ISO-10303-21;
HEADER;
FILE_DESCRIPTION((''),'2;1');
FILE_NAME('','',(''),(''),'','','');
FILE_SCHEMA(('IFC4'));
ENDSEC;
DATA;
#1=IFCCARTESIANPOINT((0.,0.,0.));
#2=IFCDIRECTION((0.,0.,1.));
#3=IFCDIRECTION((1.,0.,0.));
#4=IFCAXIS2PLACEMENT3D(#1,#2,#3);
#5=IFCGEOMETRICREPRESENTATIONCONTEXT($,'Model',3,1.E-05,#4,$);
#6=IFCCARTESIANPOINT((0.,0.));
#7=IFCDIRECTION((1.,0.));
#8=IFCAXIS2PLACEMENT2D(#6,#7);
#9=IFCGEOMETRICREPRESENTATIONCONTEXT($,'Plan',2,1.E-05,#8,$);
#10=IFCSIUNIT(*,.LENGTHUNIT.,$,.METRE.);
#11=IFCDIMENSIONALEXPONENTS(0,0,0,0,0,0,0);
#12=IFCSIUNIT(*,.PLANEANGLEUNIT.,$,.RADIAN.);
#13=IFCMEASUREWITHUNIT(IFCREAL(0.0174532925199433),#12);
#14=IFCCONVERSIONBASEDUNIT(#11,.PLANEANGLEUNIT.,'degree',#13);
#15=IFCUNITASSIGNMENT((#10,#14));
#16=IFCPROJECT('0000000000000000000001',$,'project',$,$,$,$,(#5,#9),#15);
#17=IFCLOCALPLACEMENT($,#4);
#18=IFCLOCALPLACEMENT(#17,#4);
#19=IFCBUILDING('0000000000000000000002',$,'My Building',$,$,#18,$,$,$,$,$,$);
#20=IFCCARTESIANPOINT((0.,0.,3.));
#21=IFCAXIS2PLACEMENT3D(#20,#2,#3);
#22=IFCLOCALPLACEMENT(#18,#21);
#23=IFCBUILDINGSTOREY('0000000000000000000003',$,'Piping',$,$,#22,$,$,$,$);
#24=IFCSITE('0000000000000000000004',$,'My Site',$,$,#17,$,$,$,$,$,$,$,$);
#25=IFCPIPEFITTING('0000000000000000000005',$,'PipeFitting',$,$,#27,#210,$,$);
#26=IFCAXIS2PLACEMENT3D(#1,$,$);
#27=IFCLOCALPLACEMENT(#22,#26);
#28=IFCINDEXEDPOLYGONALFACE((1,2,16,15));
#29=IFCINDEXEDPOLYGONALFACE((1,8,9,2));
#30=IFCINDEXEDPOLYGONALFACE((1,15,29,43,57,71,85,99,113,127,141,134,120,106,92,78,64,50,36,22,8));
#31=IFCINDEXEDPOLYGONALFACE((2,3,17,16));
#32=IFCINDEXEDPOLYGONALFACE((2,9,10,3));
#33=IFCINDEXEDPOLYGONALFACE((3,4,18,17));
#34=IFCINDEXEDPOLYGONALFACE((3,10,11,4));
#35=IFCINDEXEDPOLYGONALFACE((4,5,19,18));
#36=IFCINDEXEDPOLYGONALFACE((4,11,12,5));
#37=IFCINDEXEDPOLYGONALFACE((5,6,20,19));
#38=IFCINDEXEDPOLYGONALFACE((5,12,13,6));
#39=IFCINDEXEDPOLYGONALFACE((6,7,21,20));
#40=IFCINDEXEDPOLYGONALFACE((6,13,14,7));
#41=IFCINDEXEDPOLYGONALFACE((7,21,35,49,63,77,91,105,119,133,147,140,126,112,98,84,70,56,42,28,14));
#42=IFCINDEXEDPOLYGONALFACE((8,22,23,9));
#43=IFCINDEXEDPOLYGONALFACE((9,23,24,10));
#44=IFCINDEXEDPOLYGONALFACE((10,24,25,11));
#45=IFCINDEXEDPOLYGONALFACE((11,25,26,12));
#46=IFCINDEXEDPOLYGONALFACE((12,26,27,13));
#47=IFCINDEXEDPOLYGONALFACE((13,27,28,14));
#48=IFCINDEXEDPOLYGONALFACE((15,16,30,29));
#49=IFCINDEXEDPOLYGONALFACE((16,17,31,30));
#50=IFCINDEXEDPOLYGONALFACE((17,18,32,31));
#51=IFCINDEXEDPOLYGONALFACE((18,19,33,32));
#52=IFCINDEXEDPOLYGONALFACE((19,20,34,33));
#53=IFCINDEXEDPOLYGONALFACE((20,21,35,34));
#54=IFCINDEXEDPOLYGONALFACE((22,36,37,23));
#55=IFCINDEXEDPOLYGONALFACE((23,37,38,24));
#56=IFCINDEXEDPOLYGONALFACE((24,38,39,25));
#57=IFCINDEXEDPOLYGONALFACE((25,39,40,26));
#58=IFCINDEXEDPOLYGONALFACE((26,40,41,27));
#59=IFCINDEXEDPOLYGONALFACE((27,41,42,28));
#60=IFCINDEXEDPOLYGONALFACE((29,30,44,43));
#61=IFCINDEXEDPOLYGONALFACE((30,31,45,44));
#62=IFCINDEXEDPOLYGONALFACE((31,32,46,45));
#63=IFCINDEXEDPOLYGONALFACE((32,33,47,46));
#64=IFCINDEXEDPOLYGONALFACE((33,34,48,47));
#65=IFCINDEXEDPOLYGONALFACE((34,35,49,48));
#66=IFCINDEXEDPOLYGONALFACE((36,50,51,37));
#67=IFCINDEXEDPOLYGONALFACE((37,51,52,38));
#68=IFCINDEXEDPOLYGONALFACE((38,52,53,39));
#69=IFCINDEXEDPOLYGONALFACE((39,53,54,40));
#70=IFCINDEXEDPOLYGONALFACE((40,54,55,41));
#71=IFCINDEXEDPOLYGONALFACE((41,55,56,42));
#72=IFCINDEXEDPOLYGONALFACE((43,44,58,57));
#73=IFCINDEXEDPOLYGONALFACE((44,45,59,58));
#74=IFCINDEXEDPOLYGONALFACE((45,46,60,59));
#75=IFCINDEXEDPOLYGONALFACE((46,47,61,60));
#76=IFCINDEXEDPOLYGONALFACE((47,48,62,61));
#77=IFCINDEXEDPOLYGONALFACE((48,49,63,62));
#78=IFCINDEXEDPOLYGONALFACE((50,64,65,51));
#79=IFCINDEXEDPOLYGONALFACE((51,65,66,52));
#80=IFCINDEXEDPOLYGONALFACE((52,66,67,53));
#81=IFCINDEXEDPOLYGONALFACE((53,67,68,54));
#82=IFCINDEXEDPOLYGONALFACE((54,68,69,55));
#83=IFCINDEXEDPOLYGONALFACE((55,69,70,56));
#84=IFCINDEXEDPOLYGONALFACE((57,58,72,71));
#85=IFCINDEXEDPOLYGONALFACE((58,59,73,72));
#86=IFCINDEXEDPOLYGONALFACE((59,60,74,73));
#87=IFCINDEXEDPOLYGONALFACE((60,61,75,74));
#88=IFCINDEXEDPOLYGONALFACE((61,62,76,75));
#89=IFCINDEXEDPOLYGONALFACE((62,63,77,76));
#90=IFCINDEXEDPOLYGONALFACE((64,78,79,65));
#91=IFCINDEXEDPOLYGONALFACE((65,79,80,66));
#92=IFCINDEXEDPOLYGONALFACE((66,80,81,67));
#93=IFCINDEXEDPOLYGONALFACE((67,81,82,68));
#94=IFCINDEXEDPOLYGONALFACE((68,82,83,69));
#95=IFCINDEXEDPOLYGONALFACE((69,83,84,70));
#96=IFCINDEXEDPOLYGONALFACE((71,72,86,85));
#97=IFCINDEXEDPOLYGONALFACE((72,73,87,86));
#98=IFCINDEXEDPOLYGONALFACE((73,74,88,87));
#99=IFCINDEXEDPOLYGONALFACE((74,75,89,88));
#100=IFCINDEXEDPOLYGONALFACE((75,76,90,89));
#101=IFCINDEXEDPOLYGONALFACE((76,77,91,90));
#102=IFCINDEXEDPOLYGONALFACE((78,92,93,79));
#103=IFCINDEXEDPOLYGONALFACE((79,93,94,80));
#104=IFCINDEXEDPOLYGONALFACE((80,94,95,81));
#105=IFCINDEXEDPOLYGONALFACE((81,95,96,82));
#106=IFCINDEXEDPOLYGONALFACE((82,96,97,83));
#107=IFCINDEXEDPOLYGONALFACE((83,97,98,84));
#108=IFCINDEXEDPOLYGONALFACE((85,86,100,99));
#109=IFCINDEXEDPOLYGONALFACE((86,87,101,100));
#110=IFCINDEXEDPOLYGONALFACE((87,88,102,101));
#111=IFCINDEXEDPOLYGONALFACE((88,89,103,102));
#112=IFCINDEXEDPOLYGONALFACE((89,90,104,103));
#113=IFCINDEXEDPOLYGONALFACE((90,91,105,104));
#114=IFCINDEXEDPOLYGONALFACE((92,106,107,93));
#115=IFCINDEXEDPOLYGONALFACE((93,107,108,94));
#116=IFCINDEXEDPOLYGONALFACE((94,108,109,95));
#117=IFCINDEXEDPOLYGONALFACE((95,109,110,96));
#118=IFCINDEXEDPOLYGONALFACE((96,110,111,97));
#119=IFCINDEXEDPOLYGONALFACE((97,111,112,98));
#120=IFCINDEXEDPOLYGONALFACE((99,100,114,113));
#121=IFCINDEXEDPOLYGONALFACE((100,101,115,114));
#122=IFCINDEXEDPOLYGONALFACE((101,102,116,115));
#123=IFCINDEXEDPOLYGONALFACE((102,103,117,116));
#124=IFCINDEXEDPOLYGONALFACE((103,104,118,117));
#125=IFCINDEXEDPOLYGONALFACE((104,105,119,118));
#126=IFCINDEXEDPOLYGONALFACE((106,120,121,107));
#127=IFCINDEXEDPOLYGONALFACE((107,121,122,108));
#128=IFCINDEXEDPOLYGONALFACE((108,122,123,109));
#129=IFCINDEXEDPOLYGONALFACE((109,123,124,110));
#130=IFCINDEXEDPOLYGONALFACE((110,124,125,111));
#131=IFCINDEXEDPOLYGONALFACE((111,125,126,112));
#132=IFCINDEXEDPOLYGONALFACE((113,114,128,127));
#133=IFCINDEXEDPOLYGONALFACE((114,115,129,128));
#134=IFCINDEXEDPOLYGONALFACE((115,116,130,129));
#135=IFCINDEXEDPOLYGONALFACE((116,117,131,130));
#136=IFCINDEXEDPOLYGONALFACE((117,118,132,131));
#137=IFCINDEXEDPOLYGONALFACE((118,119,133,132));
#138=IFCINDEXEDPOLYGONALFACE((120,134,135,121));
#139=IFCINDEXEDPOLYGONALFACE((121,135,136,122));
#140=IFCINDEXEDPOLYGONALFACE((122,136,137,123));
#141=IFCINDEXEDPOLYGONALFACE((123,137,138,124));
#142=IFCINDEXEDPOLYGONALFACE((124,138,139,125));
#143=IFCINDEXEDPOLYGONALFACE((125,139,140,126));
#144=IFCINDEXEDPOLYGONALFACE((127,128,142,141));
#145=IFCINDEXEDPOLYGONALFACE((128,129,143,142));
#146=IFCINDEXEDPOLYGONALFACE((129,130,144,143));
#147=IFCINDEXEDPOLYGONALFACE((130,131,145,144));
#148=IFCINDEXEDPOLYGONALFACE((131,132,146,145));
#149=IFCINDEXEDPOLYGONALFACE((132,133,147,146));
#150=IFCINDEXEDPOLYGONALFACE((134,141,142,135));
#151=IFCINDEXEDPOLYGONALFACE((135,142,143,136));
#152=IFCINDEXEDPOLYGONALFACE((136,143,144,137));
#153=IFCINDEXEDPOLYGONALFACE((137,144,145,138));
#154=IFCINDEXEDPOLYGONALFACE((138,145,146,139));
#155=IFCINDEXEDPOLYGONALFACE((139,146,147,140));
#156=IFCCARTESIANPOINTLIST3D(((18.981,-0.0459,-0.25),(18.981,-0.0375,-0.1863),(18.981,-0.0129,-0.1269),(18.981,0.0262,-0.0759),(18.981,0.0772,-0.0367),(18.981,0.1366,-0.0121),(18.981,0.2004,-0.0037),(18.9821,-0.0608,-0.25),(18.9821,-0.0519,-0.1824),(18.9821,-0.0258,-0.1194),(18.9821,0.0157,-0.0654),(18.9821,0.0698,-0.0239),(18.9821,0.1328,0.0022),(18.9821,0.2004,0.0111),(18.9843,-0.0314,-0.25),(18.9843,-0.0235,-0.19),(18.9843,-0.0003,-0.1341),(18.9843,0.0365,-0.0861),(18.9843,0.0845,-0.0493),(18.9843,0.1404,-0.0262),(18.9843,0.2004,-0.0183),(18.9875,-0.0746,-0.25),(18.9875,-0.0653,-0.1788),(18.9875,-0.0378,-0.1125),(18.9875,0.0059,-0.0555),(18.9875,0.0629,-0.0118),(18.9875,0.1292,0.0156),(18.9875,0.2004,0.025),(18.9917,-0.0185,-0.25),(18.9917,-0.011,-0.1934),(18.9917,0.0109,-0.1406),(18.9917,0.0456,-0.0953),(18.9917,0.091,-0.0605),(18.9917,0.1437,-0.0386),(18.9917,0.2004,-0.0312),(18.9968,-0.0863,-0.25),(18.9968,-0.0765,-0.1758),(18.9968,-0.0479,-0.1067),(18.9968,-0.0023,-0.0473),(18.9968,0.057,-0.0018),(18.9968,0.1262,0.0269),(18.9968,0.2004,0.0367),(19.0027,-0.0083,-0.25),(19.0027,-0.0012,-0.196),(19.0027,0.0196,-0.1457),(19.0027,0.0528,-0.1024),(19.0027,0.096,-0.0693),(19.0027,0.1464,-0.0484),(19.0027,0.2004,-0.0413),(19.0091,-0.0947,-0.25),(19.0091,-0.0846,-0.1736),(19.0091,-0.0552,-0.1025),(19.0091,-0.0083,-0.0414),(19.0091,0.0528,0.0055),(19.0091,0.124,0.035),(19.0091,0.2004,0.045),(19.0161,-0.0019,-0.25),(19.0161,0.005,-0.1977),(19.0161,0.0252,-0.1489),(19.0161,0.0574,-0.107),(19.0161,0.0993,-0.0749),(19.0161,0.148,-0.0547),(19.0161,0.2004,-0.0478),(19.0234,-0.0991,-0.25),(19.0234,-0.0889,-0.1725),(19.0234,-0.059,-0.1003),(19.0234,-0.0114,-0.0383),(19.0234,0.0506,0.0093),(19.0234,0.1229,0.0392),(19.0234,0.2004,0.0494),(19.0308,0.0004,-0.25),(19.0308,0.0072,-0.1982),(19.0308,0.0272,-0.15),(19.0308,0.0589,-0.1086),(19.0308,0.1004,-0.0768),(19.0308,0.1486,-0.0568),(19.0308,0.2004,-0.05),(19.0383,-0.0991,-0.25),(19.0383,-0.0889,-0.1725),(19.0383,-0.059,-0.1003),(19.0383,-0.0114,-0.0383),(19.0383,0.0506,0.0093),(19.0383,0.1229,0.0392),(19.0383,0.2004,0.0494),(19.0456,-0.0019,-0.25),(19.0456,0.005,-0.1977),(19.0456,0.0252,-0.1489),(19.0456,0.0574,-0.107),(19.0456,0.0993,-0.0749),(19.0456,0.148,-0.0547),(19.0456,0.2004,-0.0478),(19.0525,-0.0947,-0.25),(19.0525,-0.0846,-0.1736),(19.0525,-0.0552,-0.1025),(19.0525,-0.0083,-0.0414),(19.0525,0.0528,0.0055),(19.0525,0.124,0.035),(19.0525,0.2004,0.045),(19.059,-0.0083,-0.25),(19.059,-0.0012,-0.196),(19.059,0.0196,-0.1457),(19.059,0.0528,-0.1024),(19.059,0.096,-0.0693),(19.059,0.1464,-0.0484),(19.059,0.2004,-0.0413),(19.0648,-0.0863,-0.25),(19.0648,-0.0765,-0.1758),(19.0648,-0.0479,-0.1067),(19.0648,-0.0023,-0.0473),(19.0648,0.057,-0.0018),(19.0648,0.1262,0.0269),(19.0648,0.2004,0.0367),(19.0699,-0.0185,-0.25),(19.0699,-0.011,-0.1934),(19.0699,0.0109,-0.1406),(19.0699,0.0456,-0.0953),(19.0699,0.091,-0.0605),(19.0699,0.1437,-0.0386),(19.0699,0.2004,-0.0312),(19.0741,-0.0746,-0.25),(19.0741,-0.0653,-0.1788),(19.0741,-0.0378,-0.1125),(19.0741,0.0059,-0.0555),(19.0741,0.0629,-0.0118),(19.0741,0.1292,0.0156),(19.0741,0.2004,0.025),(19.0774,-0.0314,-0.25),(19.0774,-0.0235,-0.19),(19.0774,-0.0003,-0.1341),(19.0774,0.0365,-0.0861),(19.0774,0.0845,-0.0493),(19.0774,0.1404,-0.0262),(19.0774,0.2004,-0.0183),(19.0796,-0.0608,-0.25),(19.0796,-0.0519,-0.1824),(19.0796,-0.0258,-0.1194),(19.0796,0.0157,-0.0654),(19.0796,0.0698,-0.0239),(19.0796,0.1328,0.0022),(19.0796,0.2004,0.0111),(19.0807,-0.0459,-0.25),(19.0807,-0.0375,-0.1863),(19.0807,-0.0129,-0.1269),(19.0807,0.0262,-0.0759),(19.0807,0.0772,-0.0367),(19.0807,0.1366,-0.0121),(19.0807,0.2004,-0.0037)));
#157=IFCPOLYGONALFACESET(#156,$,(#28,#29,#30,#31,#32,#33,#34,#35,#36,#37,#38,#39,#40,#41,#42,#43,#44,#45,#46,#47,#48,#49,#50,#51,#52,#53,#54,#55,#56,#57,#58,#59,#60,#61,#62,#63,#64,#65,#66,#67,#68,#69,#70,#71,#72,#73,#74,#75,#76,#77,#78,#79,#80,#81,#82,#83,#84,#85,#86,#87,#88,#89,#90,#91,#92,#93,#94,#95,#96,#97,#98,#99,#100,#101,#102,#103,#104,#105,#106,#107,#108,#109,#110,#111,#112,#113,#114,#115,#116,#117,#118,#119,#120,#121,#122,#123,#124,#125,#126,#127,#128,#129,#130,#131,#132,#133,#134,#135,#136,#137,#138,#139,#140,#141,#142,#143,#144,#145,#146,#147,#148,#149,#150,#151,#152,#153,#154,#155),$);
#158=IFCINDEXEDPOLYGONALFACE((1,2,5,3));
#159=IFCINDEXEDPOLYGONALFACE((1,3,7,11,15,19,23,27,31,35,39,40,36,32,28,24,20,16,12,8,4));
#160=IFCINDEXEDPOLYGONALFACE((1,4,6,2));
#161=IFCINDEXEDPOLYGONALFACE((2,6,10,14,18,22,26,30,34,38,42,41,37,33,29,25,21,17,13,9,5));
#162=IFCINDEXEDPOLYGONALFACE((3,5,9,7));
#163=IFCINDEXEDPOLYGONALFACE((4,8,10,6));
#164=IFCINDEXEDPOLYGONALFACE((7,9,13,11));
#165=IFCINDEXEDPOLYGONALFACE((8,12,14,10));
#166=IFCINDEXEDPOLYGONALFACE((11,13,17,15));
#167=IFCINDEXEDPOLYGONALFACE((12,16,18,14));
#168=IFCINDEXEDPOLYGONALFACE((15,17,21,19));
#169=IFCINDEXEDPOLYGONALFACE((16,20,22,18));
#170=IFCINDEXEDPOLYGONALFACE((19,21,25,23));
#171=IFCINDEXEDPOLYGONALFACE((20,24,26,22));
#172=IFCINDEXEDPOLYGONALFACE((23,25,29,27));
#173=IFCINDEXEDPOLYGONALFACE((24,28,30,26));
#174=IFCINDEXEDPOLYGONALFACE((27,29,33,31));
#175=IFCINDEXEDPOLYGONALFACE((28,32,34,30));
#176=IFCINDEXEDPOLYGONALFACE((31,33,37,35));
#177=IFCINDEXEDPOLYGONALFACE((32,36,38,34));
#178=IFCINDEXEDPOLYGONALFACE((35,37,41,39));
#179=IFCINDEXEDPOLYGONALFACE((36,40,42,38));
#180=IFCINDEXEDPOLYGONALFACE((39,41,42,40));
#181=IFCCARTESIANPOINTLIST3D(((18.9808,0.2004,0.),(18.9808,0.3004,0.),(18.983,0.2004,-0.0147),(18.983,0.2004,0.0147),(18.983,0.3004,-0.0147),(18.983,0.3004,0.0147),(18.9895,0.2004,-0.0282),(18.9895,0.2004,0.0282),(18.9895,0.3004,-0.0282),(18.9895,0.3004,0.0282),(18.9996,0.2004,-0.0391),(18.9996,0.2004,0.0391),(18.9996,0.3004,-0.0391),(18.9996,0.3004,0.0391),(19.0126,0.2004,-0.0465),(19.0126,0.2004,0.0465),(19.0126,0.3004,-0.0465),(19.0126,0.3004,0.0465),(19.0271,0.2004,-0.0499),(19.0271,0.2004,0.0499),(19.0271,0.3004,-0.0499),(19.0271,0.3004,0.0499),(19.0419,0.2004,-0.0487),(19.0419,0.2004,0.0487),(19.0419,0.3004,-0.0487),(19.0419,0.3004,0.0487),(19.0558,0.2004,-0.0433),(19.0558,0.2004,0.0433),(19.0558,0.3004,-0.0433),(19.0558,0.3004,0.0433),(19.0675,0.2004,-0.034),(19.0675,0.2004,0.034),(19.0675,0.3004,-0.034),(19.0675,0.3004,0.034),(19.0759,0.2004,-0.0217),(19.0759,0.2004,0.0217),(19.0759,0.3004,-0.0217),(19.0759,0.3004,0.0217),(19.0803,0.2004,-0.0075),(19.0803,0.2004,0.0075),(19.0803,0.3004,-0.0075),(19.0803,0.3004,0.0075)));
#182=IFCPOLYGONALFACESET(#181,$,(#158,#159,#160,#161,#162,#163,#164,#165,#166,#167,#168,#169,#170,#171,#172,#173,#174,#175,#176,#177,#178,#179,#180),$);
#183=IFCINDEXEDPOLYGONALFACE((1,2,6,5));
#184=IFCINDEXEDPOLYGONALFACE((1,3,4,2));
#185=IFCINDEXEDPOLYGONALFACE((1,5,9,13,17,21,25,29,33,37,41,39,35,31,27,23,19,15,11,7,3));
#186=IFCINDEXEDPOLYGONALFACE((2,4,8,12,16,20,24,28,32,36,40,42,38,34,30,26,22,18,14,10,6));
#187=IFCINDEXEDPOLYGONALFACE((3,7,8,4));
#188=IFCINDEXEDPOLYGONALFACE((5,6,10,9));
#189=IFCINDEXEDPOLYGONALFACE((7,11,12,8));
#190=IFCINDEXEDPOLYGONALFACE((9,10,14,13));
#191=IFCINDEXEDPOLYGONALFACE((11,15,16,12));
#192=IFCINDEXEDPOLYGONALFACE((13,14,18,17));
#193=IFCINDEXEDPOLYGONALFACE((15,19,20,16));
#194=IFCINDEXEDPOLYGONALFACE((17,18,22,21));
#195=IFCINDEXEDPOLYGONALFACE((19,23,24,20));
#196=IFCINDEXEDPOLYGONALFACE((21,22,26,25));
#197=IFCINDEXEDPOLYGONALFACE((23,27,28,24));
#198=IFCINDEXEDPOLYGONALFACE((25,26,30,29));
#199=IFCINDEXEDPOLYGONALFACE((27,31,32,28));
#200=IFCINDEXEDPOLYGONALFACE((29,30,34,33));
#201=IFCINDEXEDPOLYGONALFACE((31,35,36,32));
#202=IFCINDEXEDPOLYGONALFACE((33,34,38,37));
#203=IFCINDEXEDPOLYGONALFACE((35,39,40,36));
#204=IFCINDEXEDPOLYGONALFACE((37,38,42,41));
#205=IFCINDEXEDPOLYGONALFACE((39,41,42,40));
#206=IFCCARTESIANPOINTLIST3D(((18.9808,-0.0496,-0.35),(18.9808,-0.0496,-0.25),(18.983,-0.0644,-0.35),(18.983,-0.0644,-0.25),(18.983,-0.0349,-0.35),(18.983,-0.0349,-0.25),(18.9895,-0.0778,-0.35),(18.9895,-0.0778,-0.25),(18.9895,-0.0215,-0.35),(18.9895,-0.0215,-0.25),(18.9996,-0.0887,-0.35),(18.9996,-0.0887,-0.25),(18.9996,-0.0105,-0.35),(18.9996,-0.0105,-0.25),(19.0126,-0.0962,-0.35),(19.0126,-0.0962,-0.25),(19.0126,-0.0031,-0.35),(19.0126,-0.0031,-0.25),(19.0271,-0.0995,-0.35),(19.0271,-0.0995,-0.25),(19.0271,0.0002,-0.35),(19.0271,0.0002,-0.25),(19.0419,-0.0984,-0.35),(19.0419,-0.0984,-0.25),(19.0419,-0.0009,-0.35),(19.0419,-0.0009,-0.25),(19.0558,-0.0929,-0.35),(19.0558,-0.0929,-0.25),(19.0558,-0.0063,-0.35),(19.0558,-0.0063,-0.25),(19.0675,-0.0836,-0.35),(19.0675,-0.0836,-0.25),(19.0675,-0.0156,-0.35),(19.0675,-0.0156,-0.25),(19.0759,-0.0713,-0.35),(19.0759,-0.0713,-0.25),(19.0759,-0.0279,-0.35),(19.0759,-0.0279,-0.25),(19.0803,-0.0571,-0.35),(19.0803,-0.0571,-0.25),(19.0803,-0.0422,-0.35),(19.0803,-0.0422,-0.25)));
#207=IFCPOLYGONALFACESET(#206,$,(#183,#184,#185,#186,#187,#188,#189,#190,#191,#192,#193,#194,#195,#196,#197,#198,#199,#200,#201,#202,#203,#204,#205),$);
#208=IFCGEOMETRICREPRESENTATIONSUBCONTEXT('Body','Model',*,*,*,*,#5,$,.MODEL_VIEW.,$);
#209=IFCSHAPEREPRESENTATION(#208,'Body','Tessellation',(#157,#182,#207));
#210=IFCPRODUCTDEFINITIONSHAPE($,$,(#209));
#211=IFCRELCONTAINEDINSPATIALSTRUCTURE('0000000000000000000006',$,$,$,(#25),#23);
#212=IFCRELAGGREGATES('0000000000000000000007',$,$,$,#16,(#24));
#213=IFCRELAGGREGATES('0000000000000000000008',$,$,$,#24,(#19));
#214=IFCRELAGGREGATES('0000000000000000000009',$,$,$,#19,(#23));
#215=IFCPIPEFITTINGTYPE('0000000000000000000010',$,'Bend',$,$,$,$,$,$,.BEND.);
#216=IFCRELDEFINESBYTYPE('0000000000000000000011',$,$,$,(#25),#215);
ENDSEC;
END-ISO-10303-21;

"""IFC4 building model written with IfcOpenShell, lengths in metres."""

from ifc_helpers import new_model, entity, si_unit, converted_unit, frame, origin_with_axes, origin_2d_with_axis, place, context, subcontext, project, spatial, circle, extrude, source, transform, mapped, type_object, type_shapes, element, save


model = new_model("IFC4")

# Units and contexts
model_context = context("Model", 3, precision=1e-05, world=origin_with_axes())
plan_context = context("Plan", 2, precision=1e-05, world=origin_2d_with_axis())
body_context = subcontext(model_context, "Body", "Model", "MODEL_VIEW")
ifc_project = project(units=[si_unit("LENGTHUNIT", "METRE"), converted_unit("PLANEANGLEUNIT", "degree", entity("IfcReal", 0.0174532925199433), si_unit("PLANEANGLEUNIT", "RADIAN"), dimensions=[0, 0, 0, 0, 0, 0, 0])], contexts=[model_context, plan_context])

# Site, building, storey
site_placement = place(None, origin_with_axes())
site = spatial("IfcSite", under=ifc_project, at=site_placement, Name="My Site")
building_placement = place(site_placement, origin_with_axes())
building = spatial("IfcBuilding", under=site, at=building_placement, Name="My Building")
storey_placement = place(building_placement, frame((0.0, 0.0, 3.0), z_axis=(0.0, 0.0, 1.0), x_axis=(1.0, 0.0, 0.0)))
storey = spatial("IfcBuildingStorey", under=building, at=storey_placement, Name="Piping")

# Pipe fitting
pipe_fitting_type = type_object("IfcPipeFittingType", Name="Bend", PredefinedType="BEND")
shared_shape = source(origin_with_axes(), body_context, "Body", "SolidModel", [
    entity("IfcSweptDiskSolid", entity("IfcIndexedPolyCurve", entity("IfcCartesianPointList3D", [[0.0, 0.0, -0.1], [0.0, -0.0732, -0.2768], [0.0, -0.25, -0.35]]), [entity("IfcArcIndex", [1, 2, 3])]), 0.05),
    extrude(circle(Radius=0.05), origin_with_axes(), (0.0, 0.0, -1.0), 0.1),
    extrude(circle(Radius=0.05), frame((0.0, -0.25, -0.35), z_axis=(0.0, -1.0, 0.0), x_axis=(1.0, 0.0, 0.0)), (0.0, 0.0, 1.0), 0.1),
])
type_shapes(pipe_fitting_type, [shared_shape])
for number, where, z_axis, x_axis, name in (
    (1, (19.0308, 0.3004, 0.0), (0.0, 1.0, 0.0), (-1.0, 0.0, 0.0), "PipeFitting"),
):
    element("IfcPipeFitting", number, at=place(storey_placement, frame(where, z_axis=z_axis, x_axis=x_axis)), inside=storey, type_object=pipe_fitting_type, Name=name, context=body_context, shape_type="MappedRepresentation", body=[
        mapped(shared_shape, transform((0.0, 0.0, 0.0), x_axis=(1.0, 0.0, 0.0), y_axis=(0.0, 1.0, 0.0), z_axis=(0.0, 0.0, 1.0), scale=1.0)),
    ])

save(model, "model.ifc")
